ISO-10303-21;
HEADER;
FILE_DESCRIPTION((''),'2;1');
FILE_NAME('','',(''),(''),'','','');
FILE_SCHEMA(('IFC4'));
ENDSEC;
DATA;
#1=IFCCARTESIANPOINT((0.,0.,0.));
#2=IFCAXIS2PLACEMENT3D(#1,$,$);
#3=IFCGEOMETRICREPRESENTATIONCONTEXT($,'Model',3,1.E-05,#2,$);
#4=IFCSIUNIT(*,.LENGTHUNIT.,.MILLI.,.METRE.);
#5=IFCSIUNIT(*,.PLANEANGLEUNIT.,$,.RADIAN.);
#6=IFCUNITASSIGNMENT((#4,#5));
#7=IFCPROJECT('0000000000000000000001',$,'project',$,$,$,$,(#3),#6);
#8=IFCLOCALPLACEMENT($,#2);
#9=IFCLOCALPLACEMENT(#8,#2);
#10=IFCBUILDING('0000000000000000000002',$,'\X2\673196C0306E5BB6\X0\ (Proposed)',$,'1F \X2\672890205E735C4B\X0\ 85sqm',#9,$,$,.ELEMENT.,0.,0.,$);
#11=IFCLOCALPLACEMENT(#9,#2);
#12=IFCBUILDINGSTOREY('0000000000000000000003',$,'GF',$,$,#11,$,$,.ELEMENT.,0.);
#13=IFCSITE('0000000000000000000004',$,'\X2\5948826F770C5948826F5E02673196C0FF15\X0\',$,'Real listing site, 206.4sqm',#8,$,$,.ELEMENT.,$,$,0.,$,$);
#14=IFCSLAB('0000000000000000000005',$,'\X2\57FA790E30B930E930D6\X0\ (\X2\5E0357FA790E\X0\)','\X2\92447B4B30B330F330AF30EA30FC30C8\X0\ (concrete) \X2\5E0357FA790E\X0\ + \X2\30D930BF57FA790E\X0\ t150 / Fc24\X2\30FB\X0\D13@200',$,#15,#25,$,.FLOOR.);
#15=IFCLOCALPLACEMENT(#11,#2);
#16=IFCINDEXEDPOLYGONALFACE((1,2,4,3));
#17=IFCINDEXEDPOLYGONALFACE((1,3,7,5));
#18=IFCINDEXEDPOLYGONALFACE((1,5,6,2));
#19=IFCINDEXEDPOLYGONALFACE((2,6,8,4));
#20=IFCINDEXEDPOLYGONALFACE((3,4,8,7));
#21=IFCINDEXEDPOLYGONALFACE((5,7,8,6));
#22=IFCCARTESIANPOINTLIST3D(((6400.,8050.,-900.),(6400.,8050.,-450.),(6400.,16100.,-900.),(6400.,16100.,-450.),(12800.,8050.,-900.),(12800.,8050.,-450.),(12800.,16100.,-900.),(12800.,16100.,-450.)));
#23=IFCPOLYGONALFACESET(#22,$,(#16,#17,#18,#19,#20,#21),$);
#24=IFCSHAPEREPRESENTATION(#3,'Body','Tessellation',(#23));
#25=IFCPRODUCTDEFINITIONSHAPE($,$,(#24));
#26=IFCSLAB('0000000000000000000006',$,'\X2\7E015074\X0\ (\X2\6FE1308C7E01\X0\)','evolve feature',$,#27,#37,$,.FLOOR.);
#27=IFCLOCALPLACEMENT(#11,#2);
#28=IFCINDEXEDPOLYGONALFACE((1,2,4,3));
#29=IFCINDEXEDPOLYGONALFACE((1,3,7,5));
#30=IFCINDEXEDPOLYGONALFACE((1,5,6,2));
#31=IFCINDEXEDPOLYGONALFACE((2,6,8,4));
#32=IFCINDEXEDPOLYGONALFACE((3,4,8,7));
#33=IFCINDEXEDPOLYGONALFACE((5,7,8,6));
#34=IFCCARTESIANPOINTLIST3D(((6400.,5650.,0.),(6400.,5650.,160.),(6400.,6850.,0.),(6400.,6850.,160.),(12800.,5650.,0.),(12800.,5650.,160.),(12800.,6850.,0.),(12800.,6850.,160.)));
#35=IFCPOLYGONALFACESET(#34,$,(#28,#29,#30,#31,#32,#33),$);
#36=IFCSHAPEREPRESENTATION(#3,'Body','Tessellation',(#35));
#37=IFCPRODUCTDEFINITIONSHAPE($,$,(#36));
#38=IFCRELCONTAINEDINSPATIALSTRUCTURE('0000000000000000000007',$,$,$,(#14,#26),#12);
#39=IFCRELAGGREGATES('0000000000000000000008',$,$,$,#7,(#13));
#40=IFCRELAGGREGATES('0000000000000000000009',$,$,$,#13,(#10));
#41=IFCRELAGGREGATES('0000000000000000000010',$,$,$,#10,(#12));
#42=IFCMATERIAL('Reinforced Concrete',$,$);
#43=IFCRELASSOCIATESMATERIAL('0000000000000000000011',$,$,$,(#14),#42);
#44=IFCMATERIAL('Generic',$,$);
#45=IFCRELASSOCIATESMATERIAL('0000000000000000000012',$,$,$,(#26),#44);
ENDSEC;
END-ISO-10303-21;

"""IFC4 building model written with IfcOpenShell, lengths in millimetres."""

from ifc_helpers import new_model, si_unit, frame, frame_2d, origin, place, context, project, spatial, rectangle, extrude, material, element, save


model = new_model("IFC4")

# Units and contexts
model_context = context("Model", 3, precision=1e-05, world=origin())
ifc_project = project(units=[si_unit("LENGTHUNIT", "METRE", prefix="MILLI"), si_unit("PLANEANGLEUNIT", "RADIAN")], contexts=[model_context])

# Site, building, storey
site_placement = place(None, origin())
site = spatial("IfcSite", under=ifc_project, at=site_placement, Name="奈良県奈良市朱雀５", ObjectType="Real listing site, 206.4sqm", CompositionType="ELEMENT", RefElevation=0.0)
building_placement = place(site_placement, origin())
building = spatial("IfcBuilding", under=site, at=building_placement, Name="朱雀の家 (Proposed)", ObjectType="1F 木造平屋 85sqm", CompositionType="ELEMENT", ElevationOfRefHeight=0.0, ElevationOfTerrain=0.0)
storey_placement = place(building_placement, origin())
storey = spatial("IfcBuildingStorey", under=building, at=storey_placement, Name="GF", CompositionType="ELEMENT", Elevation=0.0)

# Slabs
ifc_material_1 = material(Name="Reinforced Concrete")
slab_1_placement = place(storey_placement, frame((3200.0, 4025.0, -450.0)))
element("IfcSlab", 1, at=slab_1_placement, inside=storey, material=ifc_material_1, Name="基礎スラブ (布基礎)", Description="鉄筋コンクリート (concrete) 布基礎 + ベタ基礎 t150 / Fc24・D13@200", PredefinedType="FLOOR", context=model_context, shape_type="SweptSolid", body=[
    extrude(rectangle(XDim=6400.0, YDim=8050.0, at=frame_2d((3200.0, 4025.0))), frame((3200.0, 4025.0, -450.0)), (0.0, 0.0, 1.0), 450.0),
])
ifc_material_2 = material(Name="Generic")
slab_2_placement = place(storey_placement, frame((3200.0, 2825.0, 0.0)))
element("IfcSlab", 2, at=slab_2_placement, inside=storey, material=ifc_material_2, Name="縁側 (濡れ縁)", Description="evolve feature", PredefinedType="FLOOR", context=model_context, shape_type="SweptSolid", body=[
    extrude(rectangle(XDim=6400.0, YDim=1200.0, at=frame_2d((3200.0, 600.0))), frame((3200.0, 2825.0, 0.0)), (0.0, 0.0, 1.0), 160.0),
])

save(model, "model.ifc")
